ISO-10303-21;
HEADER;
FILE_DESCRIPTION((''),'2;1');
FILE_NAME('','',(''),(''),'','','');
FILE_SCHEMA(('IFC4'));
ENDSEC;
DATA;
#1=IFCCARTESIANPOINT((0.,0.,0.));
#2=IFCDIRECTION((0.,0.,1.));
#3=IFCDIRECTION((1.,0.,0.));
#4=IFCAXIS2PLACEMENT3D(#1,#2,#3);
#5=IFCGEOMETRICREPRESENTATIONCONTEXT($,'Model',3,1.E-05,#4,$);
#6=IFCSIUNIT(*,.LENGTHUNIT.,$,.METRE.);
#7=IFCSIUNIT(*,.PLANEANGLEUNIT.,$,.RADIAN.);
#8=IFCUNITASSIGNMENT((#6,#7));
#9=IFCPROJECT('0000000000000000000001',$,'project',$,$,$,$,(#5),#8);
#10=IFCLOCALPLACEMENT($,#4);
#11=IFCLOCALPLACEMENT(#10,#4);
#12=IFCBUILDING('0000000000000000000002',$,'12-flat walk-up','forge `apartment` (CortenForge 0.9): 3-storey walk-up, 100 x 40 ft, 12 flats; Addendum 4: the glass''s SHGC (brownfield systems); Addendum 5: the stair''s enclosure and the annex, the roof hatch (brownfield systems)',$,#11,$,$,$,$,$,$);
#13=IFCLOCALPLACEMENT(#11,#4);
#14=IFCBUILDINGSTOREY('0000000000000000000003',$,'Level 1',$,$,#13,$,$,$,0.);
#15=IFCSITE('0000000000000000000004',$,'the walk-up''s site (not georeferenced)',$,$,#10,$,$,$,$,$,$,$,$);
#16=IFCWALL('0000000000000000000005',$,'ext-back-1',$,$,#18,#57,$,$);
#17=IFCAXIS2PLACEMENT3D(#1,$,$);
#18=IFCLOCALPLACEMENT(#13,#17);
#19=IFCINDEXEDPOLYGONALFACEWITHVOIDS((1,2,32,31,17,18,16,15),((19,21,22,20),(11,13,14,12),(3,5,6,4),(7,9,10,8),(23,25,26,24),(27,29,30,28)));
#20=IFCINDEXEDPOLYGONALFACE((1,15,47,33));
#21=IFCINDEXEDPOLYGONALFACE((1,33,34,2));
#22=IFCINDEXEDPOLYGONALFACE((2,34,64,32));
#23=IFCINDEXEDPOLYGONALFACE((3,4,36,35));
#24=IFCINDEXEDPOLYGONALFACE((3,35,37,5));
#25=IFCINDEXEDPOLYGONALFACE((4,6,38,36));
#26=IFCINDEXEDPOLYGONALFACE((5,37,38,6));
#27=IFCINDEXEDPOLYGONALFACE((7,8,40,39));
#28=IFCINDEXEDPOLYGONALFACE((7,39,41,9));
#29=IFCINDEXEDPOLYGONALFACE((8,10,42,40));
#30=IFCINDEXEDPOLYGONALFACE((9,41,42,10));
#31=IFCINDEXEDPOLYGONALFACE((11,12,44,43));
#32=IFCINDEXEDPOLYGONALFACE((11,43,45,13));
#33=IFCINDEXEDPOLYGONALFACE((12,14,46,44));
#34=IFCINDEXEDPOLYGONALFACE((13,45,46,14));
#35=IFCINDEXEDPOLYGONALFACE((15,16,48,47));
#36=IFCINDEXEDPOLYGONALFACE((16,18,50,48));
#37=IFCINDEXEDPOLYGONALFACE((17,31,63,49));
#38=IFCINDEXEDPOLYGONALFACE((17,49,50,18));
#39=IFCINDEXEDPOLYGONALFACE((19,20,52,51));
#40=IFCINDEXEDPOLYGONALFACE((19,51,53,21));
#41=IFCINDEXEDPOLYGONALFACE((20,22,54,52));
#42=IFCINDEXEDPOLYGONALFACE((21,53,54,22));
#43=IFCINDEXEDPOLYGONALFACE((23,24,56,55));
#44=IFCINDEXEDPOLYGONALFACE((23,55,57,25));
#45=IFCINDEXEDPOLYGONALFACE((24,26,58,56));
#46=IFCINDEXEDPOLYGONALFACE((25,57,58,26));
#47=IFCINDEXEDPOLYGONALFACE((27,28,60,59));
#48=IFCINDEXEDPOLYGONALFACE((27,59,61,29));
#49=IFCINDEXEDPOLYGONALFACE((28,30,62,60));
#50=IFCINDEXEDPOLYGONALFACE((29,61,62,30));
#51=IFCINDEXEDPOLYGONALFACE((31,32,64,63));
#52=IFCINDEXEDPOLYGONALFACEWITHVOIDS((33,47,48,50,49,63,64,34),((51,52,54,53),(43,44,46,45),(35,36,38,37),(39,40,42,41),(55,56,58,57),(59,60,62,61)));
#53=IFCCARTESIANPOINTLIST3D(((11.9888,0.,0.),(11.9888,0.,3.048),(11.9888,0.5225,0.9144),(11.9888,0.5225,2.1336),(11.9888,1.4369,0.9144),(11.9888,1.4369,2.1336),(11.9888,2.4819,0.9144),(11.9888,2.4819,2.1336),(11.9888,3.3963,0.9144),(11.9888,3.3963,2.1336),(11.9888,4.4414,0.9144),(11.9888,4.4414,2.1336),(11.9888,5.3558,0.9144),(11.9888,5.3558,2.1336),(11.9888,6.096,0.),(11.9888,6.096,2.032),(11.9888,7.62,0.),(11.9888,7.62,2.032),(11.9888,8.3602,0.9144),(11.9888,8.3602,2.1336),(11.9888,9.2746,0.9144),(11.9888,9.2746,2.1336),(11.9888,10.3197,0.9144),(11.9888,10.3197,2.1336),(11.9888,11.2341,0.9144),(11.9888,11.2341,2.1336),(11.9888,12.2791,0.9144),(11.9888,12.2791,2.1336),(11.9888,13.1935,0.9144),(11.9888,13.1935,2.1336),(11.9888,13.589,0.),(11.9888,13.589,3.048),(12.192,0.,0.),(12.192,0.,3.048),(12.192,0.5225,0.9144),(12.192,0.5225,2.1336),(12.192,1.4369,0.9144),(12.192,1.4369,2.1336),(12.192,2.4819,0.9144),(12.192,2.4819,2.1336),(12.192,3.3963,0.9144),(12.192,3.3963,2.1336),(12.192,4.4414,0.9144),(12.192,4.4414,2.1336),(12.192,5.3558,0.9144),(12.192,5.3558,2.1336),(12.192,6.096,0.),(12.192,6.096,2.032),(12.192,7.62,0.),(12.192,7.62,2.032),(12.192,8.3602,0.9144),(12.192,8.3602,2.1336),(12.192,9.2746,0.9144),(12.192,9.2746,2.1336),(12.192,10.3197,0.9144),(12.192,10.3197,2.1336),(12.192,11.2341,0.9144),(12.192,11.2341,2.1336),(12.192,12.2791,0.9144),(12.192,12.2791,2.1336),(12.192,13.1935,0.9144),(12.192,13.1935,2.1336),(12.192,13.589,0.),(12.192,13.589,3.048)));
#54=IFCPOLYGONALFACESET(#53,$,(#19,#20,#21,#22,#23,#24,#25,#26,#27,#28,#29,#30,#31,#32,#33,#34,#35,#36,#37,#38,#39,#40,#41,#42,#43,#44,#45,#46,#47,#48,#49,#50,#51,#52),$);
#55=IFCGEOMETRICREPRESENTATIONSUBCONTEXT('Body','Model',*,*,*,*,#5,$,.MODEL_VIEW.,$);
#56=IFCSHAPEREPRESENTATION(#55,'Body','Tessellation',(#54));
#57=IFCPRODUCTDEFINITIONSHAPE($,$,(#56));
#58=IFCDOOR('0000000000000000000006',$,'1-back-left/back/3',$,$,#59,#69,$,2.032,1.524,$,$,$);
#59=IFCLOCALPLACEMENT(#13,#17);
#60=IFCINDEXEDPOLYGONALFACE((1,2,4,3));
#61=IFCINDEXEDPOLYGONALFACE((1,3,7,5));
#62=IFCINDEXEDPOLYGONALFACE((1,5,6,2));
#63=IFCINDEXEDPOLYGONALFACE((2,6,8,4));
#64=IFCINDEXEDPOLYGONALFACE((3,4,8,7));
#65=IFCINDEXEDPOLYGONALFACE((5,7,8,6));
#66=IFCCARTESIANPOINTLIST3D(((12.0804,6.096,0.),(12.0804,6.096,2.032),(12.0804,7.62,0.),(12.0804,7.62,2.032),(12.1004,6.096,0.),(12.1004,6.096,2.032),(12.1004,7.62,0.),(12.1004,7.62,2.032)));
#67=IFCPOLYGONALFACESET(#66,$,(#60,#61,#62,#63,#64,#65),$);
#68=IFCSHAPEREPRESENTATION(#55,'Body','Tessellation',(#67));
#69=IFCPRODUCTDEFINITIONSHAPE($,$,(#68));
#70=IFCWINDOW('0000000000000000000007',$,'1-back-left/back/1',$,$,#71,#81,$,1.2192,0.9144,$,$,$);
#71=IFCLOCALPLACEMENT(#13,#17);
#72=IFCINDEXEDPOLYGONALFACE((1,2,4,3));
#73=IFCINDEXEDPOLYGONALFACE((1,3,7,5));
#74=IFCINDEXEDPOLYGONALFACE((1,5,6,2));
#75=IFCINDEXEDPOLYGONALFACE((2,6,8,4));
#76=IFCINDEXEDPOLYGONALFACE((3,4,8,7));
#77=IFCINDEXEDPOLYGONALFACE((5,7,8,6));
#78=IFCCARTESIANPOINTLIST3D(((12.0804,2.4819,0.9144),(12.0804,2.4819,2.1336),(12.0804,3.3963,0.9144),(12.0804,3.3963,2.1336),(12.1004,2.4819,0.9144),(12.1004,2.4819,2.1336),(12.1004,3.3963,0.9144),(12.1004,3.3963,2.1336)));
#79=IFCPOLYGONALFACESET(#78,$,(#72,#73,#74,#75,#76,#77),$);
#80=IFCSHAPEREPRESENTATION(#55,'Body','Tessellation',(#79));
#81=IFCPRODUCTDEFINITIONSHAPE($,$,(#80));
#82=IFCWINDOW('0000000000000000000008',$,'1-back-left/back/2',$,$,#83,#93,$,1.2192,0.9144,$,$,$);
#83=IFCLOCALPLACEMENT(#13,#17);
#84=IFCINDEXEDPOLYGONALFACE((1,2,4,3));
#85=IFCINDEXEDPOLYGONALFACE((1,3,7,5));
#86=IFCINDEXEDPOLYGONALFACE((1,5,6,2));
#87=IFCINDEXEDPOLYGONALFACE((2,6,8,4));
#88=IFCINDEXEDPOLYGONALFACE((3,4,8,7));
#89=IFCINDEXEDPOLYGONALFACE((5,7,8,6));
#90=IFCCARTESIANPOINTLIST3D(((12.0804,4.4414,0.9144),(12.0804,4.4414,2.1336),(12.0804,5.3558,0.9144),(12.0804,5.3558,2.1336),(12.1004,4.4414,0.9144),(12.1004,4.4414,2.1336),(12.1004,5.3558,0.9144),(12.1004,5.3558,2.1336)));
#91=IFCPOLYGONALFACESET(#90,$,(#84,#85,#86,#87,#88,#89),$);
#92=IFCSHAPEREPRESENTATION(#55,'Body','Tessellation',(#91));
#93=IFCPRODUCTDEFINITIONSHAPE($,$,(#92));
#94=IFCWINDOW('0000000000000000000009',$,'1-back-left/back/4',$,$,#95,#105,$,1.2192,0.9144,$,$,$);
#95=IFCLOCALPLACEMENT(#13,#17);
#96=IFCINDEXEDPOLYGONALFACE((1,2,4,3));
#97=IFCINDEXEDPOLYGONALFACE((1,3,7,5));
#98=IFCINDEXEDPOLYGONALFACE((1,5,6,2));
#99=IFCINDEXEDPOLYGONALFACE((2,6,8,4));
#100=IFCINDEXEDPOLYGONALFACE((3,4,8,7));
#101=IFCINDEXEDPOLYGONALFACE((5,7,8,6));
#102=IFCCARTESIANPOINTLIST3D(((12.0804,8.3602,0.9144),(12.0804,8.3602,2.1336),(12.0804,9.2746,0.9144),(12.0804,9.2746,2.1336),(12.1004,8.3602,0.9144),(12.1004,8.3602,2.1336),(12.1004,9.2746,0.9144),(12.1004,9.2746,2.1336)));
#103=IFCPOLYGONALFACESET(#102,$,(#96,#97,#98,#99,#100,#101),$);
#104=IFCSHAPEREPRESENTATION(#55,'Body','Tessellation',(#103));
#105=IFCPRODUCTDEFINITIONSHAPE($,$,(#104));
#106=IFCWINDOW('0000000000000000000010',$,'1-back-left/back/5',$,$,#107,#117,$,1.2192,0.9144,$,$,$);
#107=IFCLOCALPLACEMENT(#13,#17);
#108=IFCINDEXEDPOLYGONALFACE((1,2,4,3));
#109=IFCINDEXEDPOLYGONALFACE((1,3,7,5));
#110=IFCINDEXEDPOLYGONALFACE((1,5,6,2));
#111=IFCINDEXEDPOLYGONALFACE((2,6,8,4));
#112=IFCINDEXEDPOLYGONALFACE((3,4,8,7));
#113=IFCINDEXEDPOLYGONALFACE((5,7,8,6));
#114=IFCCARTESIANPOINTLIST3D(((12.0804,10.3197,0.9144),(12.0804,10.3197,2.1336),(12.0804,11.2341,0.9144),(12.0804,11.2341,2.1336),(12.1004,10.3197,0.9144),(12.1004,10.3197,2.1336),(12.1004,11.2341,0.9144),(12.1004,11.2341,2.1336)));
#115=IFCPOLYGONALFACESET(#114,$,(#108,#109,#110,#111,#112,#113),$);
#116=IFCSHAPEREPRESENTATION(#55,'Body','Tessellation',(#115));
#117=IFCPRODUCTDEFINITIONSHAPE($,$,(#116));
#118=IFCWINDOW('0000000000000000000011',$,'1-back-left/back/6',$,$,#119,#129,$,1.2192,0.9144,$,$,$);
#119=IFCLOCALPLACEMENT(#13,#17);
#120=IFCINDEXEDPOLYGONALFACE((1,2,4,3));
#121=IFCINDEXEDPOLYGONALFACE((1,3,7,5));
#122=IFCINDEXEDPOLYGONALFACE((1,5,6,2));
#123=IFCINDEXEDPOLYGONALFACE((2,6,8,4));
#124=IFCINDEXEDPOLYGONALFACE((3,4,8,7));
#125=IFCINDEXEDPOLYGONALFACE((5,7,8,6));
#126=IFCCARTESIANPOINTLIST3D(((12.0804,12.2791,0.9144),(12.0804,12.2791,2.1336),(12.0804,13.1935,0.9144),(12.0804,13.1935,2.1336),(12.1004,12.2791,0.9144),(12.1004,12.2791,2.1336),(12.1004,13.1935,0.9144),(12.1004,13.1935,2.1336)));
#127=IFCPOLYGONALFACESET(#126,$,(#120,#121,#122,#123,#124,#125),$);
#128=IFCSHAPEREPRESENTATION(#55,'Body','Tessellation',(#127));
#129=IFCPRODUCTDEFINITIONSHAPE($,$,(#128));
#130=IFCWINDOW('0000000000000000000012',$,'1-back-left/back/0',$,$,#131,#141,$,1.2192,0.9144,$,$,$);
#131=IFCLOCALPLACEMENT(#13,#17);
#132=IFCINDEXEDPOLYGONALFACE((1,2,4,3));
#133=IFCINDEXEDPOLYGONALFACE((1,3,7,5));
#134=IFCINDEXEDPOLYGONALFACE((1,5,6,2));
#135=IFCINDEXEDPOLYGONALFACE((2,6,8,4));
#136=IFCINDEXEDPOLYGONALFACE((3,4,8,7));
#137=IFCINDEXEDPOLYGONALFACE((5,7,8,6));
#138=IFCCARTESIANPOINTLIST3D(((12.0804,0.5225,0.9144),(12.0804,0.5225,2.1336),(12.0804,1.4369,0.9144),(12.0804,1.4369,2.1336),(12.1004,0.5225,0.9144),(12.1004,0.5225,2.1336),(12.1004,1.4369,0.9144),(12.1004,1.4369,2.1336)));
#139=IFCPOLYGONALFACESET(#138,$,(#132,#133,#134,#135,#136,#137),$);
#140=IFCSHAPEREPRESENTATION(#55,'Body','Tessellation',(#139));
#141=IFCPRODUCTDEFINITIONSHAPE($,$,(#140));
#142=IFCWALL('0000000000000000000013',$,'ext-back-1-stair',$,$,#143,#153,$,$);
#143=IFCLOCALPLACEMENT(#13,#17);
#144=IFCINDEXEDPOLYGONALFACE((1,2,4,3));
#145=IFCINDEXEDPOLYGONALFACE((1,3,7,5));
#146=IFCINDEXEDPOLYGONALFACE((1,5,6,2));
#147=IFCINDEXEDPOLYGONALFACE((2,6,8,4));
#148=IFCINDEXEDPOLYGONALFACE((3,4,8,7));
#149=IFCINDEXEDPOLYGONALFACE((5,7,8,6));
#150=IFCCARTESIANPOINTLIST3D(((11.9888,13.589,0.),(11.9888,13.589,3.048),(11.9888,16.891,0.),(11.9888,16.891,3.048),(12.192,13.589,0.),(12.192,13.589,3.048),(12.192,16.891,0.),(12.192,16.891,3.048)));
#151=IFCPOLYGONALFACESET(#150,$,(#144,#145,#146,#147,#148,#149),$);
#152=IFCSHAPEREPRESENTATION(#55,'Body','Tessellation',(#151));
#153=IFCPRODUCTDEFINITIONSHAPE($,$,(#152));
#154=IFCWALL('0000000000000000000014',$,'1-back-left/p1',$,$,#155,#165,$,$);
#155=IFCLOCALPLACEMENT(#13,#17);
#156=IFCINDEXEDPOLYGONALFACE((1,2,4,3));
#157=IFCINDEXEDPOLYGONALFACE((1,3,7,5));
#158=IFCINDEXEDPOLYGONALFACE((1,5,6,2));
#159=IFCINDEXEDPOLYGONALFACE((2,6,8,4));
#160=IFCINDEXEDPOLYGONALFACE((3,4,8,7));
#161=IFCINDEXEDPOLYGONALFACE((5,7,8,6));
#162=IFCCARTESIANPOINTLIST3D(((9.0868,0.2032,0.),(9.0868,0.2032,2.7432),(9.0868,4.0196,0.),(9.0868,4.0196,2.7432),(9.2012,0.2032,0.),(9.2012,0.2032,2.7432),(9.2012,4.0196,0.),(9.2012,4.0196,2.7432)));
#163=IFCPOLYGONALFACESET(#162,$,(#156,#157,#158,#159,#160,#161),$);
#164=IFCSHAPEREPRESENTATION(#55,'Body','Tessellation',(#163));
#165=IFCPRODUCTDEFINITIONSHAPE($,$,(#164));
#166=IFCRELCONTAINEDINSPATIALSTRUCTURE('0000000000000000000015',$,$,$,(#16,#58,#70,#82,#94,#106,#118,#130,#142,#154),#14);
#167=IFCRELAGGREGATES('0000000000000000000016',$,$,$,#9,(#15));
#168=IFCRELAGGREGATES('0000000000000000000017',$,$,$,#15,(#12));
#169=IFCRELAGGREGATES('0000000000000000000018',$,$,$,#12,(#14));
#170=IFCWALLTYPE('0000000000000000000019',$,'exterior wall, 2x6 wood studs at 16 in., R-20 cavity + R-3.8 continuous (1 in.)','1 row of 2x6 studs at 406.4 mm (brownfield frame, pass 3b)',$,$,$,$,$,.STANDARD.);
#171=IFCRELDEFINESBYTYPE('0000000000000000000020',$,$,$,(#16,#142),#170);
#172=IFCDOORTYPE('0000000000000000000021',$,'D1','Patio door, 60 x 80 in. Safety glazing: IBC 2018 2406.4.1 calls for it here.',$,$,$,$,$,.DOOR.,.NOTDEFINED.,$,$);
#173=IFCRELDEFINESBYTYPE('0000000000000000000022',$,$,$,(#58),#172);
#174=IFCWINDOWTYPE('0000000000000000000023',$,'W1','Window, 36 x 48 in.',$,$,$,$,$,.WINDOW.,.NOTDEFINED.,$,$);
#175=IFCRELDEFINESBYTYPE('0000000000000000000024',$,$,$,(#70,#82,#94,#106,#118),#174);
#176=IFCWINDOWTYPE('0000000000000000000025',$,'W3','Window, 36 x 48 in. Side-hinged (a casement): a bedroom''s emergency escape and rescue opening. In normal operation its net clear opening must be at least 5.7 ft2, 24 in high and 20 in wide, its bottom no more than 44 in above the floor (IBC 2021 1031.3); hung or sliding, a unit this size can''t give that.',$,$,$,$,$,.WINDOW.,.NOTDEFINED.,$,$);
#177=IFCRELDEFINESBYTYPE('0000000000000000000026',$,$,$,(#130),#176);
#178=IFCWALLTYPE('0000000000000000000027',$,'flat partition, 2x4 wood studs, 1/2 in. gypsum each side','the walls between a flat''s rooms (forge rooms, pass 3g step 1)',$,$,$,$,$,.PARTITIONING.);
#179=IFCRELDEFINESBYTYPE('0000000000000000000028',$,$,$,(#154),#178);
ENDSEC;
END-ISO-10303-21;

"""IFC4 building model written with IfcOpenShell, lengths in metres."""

from ifc_helpers import new_model, si_unit, frame, frame_2d, origin, origin_with_axes, place, context, subcontext, project, spatial, rectangle, extrude, type_object, element, fill, save


model = new_model("IFC4")

# Units and contexts
model_context = context("Model", 3, precision=1e-05, world=origin_with_axes())
body_context = subcontext(model_context, "Body", "Model", "MODEL_VIEW")
ifc_project = project(units=[si_unit("LENGTHUNIT", "METRE"), si_unit("PLANEANGLEUNIT", "RADIAN")], contexts=[model_context])

# Site, building, storey
site_placement = place(None, origin_with_axes())
site = spatial("IfcSite", under=ifc_project, at=site_placement, Name="the walk-up's site (not georeferenced)")
building_placement = place(site_placement, origin_with_axes())
building = spatial("IfcBuilding", under=site, at=building_placement, Name="12-flat walk-up", Description="forge `apartment` (CortenForge 0.9): 3-storey walk-up, 100 x 40 ft, 12 flats; Addendum 4: the glass's SHGC (brownfield systems); Addendum 5: the stair's enclosure and the annex, the roof hatch (brownfield systems)")
storey_placement = place(building_placement, origin_with_axes())
storey = spatial("IfcBuildingStorey", under=building, at=storey_placement, Name="Level 1", Elevation=0.0)

# Wall, openings, door, windows
wall_type_1 = type_object("IfcWallType", Name="exterior wall, 2x6 wood studs at 16 in., R-20 cavity + R-3.8 continuous (1 in.)", Description="1 row of 2x6 studs at 406.4 mm (brownfield frame, pass 3b)", PredefinedType="STANDARD")
wall_1_placement = place(storey_placement, frame((11.9888, 0.0, 0.0), z_axis=(0.0, 0.0, 1.0), x_axis=(1.0, 0.0, 0.0)))
wall_1 = element("IfcWall", 1, at=wall_1_placement, inside=storey, type_object=wall_type_1, Name="ext-back-1", context=body_context, shape_type="SweptSolid", body=[
    extrude(rectangle(XDim=0.2032, YDim=13.589, at=frame_2d((0.1016, 6.7945))), origin(), (0.0, 0.0, 1.0), 3.048),
])
opening_1_placement = place(wall_1_placement, frame((0.2032, 0.5225, 0.9144), z_axis=(0.0, 0.0, 1.0), x_axis=(0.0, 1.0, 0.0)))
opening_1 = element("IfcOpeningElement", 2, at=opening_1_placement, cuts=wall_1, PredefinedType="OPENING", context=body_context, shape_type="SweptSolid", body=[
    extrude(rectangle(XDim=0.9144, YDim=0.2032, at=frame_2d((0.4572, 0.1016))), origin(), (0.0, 0.0, 1.0), 1.2192),
])
opening_2_placement = place(wall_1_placement, frame((0.2032, 2.4819, 0.9144), z_axis=(0.0, 0.0, 1.0), x_axis=(0.0, 1.0, 0.0)))
opening_2 = element("IfcOpeningElement", 3, at=opening_2_placement, cuts=wall_1, PredefinedType="OPENING", context=body_context, shape_type="SweptSolid", body=[
    extrude(rectangle(XDim=0.9144, YDim=0.2032, at=frame_2d((0.4572, 0.1016))), origin(), (0.0, 0.0, 1.0), 1.2192),
])
opening_3_placement = place(wall_1_placement, frame((0.2032, 4.4414, 0.9144), z_axis=(0.0, 0.0, 1.0), x_axis=(0.0, 1.0, 0.0)))
opening_3 = element("IfcOpeningElement", 4, at=opening_3_placement, cuts=wall_1, PredefinedType="OPENING", context=body_context, shape_type="SweptSolid", body=[
    extrude(rectangle(XDim=0.9144, YDim=0.2032, at=frame_2d((0.4572, 0.1016))), origin(), (0.0, 0.0, 1.0), 1.2192),
])
opening_4_placement = place(wall_1_placement, frame((0.2032, 6.096, 0.0), z_axis=(0.0, 0.0, 1.0), x_axis=(0.0, 1.0, 0.0)))
opening_4 = element("IfcOpeningElement", 5, at=opening_4_placement, cuts=wall_1, PredefinedType="OPENING", context=body_context, shape_type="SweptSolid", body=[
    extrude(rectangle(XDim=1.524, YDim=0.2032, at=frame_2d((0.762, 0.1016))), origin(), (0.0, 0.0, 1.0), 2.032),
])
opening_5_placement = place(wall_1_placement, frame((0.2032, 8.3602, 0.9144), z_axis=(0.0, 0.0, 1.0), x_axis=(0.0, 1.0, 0.0)))
opening_5 = element("IfcOpeningElement", 6, at=opening_5_placement, cuts=wall_1, PredefinedType="OPENING", context=body_context, shape_type="SweptSolid", body=[
    extrude(rectangle(XDim=0.9144, YDim=0.2032, at=frame_2d((0.4572, 0.1016))), origin(), (0.0, 0.0, 1.0), 1.2192),
])
opening_6_placement = place(wall_1_placement, frame((0.2032, 10.3197, 0.9144), z_axis=(0.0, 0.0, 1.0), x_axis=(0.0, 1.0, 0.0)))
opening_6 = element("IfcOpeningElement", 7, at=opening_6_placement, cuts=wall_1, PredefinedType="OPENING", context=body_context, shape_type="SweptSolid", body=[
    extrude(rectangle(XDim=0.9144, YDim=0.2032, at=frame_2d((0.4572, 0.1016))), origin(), (0.0, 0.0, 1.0), 1.2192),
])
opening_7_placement = place(wall_1_placement, frame((0.2032, 12.2791, 0.9144), z_axis=(0.0, 0.0, 1.0), x_axis=(0.0, 1.0, 0.0)))
opening_7 = element("IfcOpeningElement", 8, at=opening_7_placement, cuts=wall_1, PredefinedType="OPENING", context=body_context, shape_type="SweptSolid", body=[
    extrude(rectangle(XDim=0.9144, YDim=0.2032, at=frame_2d((0.4572, 0.1016))), origin(), (0.0, 0.0, 1.0), 1.2192),
])
door_type_1 = type_object("IfcDoorType", Name="D1", Description="Patio door, 60 x 80 in. Safety glazing: IBC 2018 2406.4.1 calls for it here.", OperationType="NOTDEFINED", PredefinedType="DOOR")
door_1_placement = place(opening_4_placement, frame((0.0, 0.0916, 0.0), z_axis=(0.0, 0.0, 1.0), x_axis=(1.0, 0.0, 0.0)))
door_1 = element("IfcDoor", 9, at=door_1_placement, inside=storey, type_object=door_type_1, Name="1-back-left/back/3", OverallHeight=2.032, OverallWidth=1.524, context=body_context, shape_type="SweptSolid", body=[
    extrude(rectangle(XDim=1.524, YDim=0.02, at=frame_2d((0.762, 0.01))), origin(), (0.0, 0.0, 1.0), 2.032),
])
fill(opening_4, door_1)
window_type_1 = type_object("IfcWindowType", Name="W1", Description="Window, 36 x 48 in.", PartitioningType="NOTDEFINED", PredefinedType="WINDOW")
window_1_placement = place(opening_2_placement, frame((0.0, 0.0916, 0.0), z_axis=(0.0, 0.0, 1.0), x_axis=(1.0, 0.0, 0.0)))
window_1 = element("IfcWindow", 10, at=window_1_placement, inside=storey, type_object=window_type_1, Name="1-back-left/back/1", OverallHeight=1.2192, OverallWidth=0.9144, context=body_context, shape_type="SweptSolid", body=[
    extrude(rectangle(XDim=0.9144, YDim=0.02, at=frame_2d((0.4572, 0.01))), origin(), (0.0, 0.0, 1.0), 1.2192),
])
fill(opening_2, window_1)
window_2_placement = place(opening_3_placement, frame((0.0, 0.0916, 0.0), z_axis=(0.0, 0.0, 1.0), x_axis=(1.0, 0.0, 0.0)))
window_2 = element("IfcWindow", 11, at=window_2_placement, inside=storey, type_object=window_type_1, Name="1-back-left/back/2", OverallHeight=1.2192, OverallWidth=0.9144, context=body_context, shape_type="SweptSolid", body=[
    extrude(rectangle(XDim=0.9144, YDim=0.02, at=frame_2d((0.4572, 0.01))), origin(), (0.0, 0.0, 1.0), 1.2192),
])
fill(opening_3, window_2)
window_3_placement = place(opening_5_placement, frame((0.0, 0.0916, 0.0), z_axis=(0.0, 0.0, 1.0), x_axis=(1.0, 0.0, 0.0)))
window_3 = element("IfcWindow", 12, at=window_3_placement, inside=storey, type_object=window_type_1, Name="1-back-left/back/4", OverallHeight=1.2192, OverallWidth=0.9144, context=body_context, shape_type="SweptSolid", body=[
    extrude(rectangle(XDim=0.9144, YDim=0.02, at=frame_2d((0.4572, 0.01))), origin(), (0.0, 0.0, 1.0), 1.2192),
])
fill(opening_5, window_3)
window_4_placement = place(opening_6_placement, frame((0.0, 0.0916, 0.0), z_axis=(0.0, 0.0, 1.0), x_axis=(1.0, 0.0, 0.0)))
window_4 = element("IfcWindow", 13, at=window_4_placement, inside=storey, type_object=window_type_1, Name="1-back-left/back/5", OverallHeight=1.2192, OverallWidth=0.9144, context=body_context, shape_type="SweptSolid", body=[
    extrude(rectangle(XDim=0.9144, YDim=0.02, at=frame_2d((0.4572, 0.01))), origin(), (0.0, 0.0, 1.0), 1.2192),
])
fill(opening_6, window_4)
window_5_placement = place(opening_7_placement, frame((0.0, 0.0916, 0.0), z_axis=(0.0, 0.0, 1.0), x_axis=(1.0, 0.0, 0.0)))
window_5 = element("IfcWindow", 14, at=window_5_placement, inside=storey, type_object=window_type_1, Name="1-back-left/back/6", OverallHeight=1.2192, OverallWidth=0.9144, context=body_context, shape_type="SweptSolid", body=[
    extrude(rectangle(XDim=0.9144, YDim=0.02, at=frame_2d((0.4572, 0.01))), origin(), (0.0, 0.0, 1.0), 1.2192),
])
fill(opening_7, window_5)
window_type_2 = type_object("IfcWindowType", Name="W3", Description="Window, 36 x 48 in. Side-hinged (a casement): a bedroom's emergency escape and rescue opening. In normal operation its net clear opening must be at least 5.7 ft2, 24 in high and 20 in wide, its bottom no more than 44 in above the floor (IBC 2021 1031.3); hung or sliding, a unit this size can't give that.", PartitioningType="NOTDEFINED", PredefinedType="WINDOW")
window_6_placement = place(opening_1_placement, frame((0.0, 0.0916, 0.0), z_axis=(0.0, 0.0, 1.0), x_axis=(1.0, 0.0, 0.0)))
window_6 = element("IfcWindow", 15, at=window_6_placement, inside=storey, type_object=window_type_2, Name="1-back-left/back/0", OverallHeight=1.2192, OverallWidth=0.9144, context=body_context, shape_type="SweptSolid", body=[
    extrude(rectangle(XDim=0.9144, YDim=0.02, at=frame_2d((0.4572, 0.01))), origin(), (0.0, 0.0, 1.0), 1.2192),
])
fill(opening_1, window_6)

# Walls
wall_2_placement = place(storey_placement, frame((11.9888, 13.589, 0.0), z_axis=(0.0, 0.0, 1.0), x_axis=(1.0, 0.0, 0.0)))
element("IfcWall", 16, at=wall_2_placement, inside=storey, type_object=wall_type_1, Name="ext-back-1-stair", context=body_context, shape_type="SweptSolid", body=[
    extrude(rectangle(XDim=0.2032, YDim=3.302, at=frame_2d((0.1016, 1.651))), origin(), (0.0, 0.0, 1.0), 3.048),
])
wall_type_2 = type_object("IfcWallType", Name="flat partition, 2x4 wood studs, 1/2 in. gypsum each side", Description="the walls between a flat's rooms (forge rooms, pass 3g step 1)", PredefinedType="PARTITIONING")
wall_3_placement = place(storey_placement, frame((9.0869, 0.2032, 0.0), z_axis=(0.0, 0.0, 1.0), x_axis=(1.0, 0.0, 0.0)))
element("IfcWall", 17, at=wall_3_placement, inside=storey, type_object=wall_type_2, Name="1-back-left/p1", context=body_context, shape_type="SweptSolid", body=[
    extrude(rectangle(XDim=0.1143, YDim=3.8163, at=frame_2d((0.0572, 1.9082))), origin(), (0.0, 0.0, 1.0), 2.7432),
])

save(model, "model.ifc")
